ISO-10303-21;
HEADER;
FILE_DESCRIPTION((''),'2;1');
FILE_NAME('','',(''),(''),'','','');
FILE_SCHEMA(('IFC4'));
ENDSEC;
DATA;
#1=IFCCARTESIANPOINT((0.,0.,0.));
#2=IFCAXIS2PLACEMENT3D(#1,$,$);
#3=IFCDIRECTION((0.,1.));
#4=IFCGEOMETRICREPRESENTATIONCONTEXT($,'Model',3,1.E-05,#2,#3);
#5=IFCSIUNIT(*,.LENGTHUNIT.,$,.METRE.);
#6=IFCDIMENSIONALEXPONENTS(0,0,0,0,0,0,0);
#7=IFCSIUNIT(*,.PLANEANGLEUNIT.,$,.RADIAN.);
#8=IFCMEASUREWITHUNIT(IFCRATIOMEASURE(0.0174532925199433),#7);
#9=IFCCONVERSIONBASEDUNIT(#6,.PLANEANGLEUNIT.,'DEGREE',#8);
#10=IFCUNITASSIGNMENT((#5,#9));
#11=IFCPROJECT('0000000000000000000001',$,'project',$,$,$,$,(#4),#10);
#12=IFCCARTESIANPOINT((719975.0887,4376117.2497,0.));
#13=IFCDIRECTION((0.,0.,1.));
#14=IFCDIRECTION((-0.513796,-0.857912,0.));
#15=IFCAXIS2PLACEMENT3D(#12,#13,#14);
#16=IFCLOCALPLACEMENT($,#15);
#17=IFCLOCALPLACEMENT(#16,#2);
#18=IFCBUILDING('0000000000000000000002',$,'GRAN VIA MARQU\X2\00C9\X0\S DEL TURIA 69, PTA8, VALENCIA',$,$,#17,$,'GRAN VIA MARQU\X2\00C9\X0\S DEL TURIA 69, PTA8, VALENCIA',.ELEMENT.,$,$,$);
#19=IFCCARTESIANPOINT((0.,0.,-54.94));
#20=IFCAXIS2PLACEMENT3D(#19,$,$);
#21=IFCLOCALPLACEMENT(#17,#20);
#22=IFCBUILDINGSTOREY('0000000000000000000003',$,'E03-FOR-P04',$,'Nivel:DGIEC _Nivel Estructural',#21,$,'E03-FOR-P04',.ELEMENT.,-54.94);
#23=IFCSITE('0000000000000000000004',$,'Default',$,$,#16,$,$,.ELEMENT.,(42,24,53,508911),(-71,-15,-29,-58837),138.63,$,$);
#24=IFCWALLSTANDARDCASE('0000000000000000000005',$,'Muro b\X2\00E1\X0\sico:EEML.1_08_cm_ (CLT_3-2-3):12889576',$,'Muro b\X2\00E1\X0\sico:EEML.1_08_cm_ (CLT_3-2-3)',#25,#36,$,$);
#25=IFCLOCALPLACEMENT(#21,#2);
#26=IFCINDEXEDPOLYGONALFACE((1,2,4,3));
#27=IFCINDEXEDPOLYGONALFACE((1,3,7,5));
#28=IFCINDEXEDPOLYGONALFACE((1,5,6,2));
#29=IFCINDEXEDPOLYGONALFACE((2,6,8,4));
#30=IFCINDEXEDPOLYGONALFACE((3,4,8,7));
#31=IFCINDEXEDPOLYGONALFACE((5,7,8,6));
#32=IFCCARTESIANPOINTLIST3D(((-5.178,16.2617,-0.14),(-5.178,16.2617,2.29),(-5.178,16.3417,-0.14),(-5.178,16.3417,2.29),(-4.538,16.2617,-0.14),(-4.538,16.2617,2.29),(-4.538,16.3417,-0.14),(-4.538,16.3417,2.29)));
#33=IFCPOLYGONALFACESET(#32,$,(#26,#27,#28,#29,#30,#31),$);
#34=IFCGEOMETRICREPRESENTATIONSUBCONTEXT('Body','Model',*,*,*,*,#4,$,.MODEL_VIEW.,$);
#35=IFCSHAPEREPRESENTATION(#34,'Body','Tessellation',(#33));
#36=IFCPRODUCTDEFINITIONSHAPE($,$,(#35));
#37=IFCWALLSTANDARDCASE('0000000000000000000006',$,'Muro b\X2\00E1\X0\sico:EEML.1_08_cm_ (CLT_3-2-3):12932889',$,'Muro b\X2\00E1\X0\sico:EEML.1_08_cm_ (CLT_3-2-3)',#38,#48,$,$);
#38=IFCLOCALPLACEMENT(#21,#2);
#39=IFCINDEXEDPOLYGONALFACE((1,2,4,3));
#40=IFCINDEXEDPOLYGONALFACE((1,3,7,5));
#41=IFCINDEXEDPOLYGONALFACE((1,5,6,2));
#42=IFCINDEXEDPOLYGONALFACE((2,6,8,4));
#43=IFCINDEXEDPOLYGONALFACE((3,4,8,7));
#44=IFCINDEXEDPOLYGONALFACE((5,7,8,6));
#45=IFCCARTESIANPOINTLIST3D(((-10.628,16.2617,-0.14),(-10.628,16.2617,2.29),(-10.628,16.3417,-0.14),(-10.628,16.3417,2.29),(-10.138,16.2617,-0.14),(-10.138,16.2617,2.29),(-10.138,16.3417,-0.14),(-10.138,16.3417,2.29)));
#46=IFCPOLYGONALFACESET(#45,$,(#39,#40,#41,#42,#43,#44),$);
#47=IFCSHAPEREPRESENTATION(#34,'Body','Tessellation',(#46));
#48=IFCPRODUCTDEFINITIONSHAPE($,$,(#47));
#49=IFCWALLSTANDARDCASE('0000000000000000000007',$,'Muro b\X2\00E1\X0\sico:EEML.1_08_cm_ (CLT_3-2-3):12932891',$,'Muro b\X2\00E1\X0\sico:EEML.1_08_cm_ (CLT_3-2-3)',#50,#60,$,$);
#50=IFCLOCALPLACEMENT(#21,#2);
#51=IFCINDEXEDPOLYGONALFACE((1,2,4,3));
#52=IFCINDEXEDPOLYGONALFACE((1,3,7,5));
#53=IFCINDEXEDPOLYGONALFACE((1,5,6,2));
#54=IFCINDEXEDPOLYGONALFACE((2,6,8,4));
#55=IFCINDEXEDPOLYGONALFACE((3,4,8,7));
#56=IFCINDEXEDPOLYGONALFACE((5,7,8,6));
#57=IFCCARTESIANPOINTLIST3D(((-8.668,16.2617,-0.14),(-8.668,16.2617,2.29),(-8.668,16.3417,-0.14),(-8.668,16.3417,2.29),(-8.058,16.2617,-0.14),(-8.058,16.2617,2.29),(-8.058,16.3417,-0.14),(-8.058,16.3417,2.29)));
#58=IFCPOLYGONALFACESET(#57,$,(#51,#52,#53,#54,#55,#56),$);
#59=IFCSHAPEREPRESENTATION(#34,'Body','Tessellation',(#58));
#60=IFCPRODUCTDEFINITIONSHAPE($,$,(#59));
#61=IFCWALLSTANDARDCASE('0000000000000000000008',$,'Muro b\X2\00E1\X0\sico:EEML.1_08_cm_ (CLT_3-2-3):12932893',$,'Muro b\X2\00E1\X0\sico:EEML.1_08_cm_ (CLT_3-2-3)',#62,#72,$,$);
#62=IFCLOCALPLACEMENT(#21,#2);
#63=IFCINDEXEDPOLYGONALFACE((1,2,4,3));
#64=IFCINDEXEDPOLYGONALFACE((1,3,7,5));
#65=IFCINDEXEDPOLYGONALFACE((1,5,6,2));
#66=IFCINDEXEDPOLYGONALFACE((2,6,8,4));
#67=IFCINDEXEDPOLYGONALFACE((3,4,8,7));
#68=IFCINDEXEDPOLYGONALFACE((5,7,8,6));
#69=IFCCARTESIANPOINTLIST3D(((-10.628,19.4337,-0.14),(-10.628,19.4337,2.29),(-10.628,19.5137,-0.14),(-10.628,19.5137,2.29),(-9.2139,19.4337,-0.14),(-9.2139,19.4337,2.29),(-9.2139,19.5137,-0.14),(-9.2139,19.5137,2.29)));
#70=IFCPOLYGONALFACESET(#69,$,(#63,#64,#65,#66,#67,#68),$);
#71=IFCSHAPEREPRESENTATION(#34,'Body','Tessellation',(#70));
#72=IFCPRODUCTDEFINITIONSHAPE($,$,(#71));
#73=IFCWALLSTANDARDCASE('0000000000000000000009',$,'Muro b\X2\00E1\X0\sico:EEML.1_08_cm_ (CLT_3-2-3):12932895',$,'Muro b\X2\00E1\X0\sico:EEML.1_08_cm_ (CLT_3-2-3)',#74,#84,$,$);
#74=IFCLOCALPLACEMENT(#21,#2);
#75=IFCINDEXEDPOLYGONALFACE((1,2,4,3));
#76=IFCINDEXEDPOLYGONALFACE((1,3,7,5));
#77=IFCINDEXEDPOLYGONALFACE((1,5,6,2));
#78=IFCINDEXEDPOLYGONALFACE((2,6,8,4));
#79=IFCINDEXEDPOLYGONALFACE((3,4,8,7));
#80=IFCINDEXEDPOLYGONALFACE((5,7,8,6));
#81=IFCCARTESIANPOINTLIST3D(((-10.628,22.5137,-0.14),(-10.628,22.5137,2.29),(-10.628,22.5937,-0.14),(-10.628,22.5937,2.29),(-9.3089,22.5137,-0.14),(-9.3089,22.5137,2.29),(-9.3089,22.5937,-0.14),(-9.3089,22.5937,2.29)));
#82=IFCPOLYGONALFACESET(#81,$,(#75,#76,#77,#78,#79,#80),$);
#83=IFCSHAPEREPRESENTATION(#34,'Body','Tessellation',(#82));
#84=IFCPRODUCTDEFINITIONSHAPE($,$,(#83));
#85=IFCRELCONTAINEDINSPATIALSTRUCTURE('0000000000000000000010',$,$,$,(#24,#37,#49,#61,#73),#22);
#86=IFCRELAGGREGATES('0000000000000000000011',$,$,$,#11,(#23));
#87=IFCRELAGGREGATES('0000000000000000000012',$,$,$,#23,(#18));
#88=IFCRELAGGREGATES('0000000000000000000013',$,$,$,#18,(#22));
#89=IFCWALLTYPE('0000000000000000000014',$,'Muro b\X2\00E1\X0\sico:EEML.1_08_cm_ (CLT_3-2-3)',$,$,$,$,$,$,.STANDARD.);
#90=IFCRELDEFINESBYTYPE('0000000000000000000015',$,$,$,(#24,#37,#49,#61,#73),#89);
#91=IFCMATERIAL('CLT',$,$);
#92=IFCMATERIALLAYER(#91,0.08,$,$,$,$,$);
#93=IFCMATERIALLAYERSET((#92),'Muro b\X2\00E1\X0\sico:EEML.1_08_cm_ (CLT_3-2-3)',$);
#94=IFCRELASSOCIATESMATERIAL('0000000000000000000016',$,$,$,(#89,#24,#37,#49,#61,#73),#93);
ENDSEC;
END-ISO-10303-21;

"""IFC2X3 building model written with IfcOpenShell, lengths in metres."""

from ifc_helpers import new_model, entity, si_unit, converted_unit, direction, frame, frame_2d, origin, place, context, subcontext, project, spatial, rectangle, extrude, material, layer, layer_set, layer_usage, type_object, element, save


model = new_model("IFC2X3")

# Units and contexts
model_context = context("Model", 3, precision=1e-05, world=origin(), true_north=direction((0.0, 1.0)))
body_context = subcontext(model_context, "Body", "Model", "MODEL_VIEW")
ifc_project = project(units=[si_unit("LENGTHUNIT", "METRE"), converted_unit("PLANEANGLEUNIT", "DEGREE", entity("IfcRatioMeasure", 0.0174532925199433), si_unit("PLANEANGLEUNIT", "RADIAN"), dimensions=[0, 0, 0, 0, 0, 0, 0])], contexts=[model_context])

# Site, building, storey
site_placement = place(None, frame((719975.0887, 4376117.2497, 0.0), z_axis=(0.0, 0.0, 1.0), x_axis=(-0.513796, -0.857912, 0.0)))
site = spatial("IfcSite", under=ifc_project, at=site_placement, Name="Default", CompositionType="ELEMENT", RefLatitude=(42, 24, 53, 508911), RefLongitude=(-71, -15, -29, -58837), RefElevation=138.63)
building_placement = place(site_placement, origin())
building = spatial("IfcBuilding", under=site, at=building_placement, Name="GRAN VIA MARQUÉS DEL TURIA 69, PTA8, VALENCIA", LongName="GRAN VIA MARQUÉS DEL TURIA 69, PTA8, VALENCIA", CompositionType="ELEMENT")
storey_placement = place(building_placement, frame((0.0, 0.0, -54.94)))
storey = spatial("IfcBuildingStorey", under=building, at=storey_placement, Name="E03-FOR-P04", ObjectType="Nivel:DGIEC _Nivel Estructural", LongName="E03-FOR-P04", CompositionType="ELEMENT", Elevation=-54.94)

# Shared definitions
ifc_material = material(Name="CLT")

# Walls
ifc_layer_1 = layer(ifc_material, 0.08)
ifc_layer_set_1 = layer_set([ifc_layer_1], Name="Muro básico:EEML.1_08_cm_ (CLT_3-2-3)")
ifc_layer_usage_1 = layer_usage(ifc_layer_set_1, "AXIS2", "NEGATIVE", 0.04)
wall_type_1 = type_object("IfcWallType", Name="Muro básico:EEML.1_08_cm_ (CLT_3-2-3)", PredefinedType="STANDARD", material=ifc_layer_set_1)
wall_1_placement = place(storey_placement, frame((-4.538, 16.3017, -0.14), z_axis=(0.0, 0.0, 1.0), x_axis=(-1.0, 0.0, 0.0)))
element("IfcWallStandardCase", 1, at=wall_1_placement, inside=storey, type_object=wall_type_1, material=ifc_layer_usage_1, Name="Muro básico:EEML.1_08_cm_ (CLT_3-2-3):12889576", ObjectType="Muro básico:EEML.1_08_cm_ (CLT_3-2-3)", context=body_context, shape_type="SweptSolid", body=[
    extrude(rectangle(XDim=0.64, YDim=0.08, at=frame_2d((0.32, 0.0), x_axis=(-1.0, 0.0))), origin(), (0.0, 0.0, 1.0), 2.43),
])
ifc_layer_usage_2 = layer_usage(ifc_layer_set_1, "AXIS2", "NEGATIVE", 0.04)
wall_2_placement = place(storey_placement, frame((-10.138, 16.3017, -0.14), z_axis=(0.0, 0.0, 1.0), x_axis=(-1.0, 0.0, 0.0)))
element("IfcWallStandardCase", 2, at=wall_2_placement, inside=storey, type_object=wall_type_1, material=ifc_layer_usage_2, Name="Muro básico:EEML.1_08_cm_ (CLT_3-2-3):12932889", ObjectType="Muro básico:EEML.1_08_cm_ (CLT_3-2-3)", context=body_context, shape_type="SweptSolid", body=[
    extrude(rectangle(XDim=0.49, YDim=0.08, at=frame_2d((0.245, 0.0), x_axis=(-1.0, 0.0))), origin(), (0.0, 0.0, 1.0), 2.43),
])
ifc_layer_usage_3 = layer_usage(ifc_layer_set_1, "AXIS2", "NEGATIVE", 0.04)
wall_3_placement = place(storey_placement, frame((-8.058, 16.3017, -0.14), z_axis=(0.0, 0.0, 1.0), x_axis=(-1.0, 0.0, 0.0)))
element("IfcWallStandardCase", 3, at=wall_3_placement, inside=storey, type_object=wall_type_1, material=ifc_layer_usage_3, Name="Muro básico:EEML.1_08_cm_ (CLT_3-2-3):12932891", ObjectType="Muro básico:EEML.1_08_cm_ (CLT_3-2-3)", context=body_context, shape_type="SweptSolid", body=[
    extrude(rectangle(XDim=0.61, YDim=0.08, at=frame_2d((0.305, 0.0), x_axis=(-1.0, 0.0))), origin(), (0.0, 0.0, 1.0), 2.43),
])
ifc_layer_usage_4 = layer_usage(ifc_layer_set_1, "AXIS2", "NEGATIVE", 0.04)
wall_4_placement = place(storey_placement, frame((-9.2139, 19.4737, -0.14), z_axis=(0.0, 0.0, 1.0), x_axis=(-1.0, 0.0, 0.0)))
element("IfcWallStandardCase", 4, at=wall_4_placement, inside=storey, type_object=wall_type_1, material=ifc_layer_usage_4, Name="Muro básico:EEML.1_08_cm_ (CLT_3-2-3):12932893", ObjectType="Muro básico:EEML.1_08_cm_ (CLT_3-2-3)", context=body_context, shape_type="SweptSolid", body=[
    extrude(rectangle(XDim=1.4142, YDim=0.08, at=frame_2d((0.7071, 0.0), x_axis=(-1.0, 0.0))), origin(), (0.0, 0.0, 1.0), 2.43),
])
ifc_layer_usage_5 = layer_usage(ifc_layer_set_1, "AXIS2", "NEGATIVE", 0.04)
wall_5_placement = place(storey_placement, frame((-9.3089, 22.5537, -0.14), z_axis=(0.0, 0.0, 1.0), x_axis=(-1.0, 0.0, 0.0)))
element("IfcWallStandardCase", 5, at=wall_5_placement, inside=storey, type_object=wall_type_1, material=ifc_layer_usage_5, Name="Muro básico:EEML.1_08_cm_ (CLT_3-2-3):12932895", ObjectType="Muro básico:EEML.1_08_cm_ (CLT_3-2-3)", context=body_context, shape_type="SweptSolid", body=[
    extrude(rectangle(XDim=1.3192, YDim=0.08, at=frame_2d((0.6596, 0.0), x_axis=(-1.0, 0.0))), origin(), (0.0, 0.0, 1.0), 2.43),
])

save(model, "model.ifc")
